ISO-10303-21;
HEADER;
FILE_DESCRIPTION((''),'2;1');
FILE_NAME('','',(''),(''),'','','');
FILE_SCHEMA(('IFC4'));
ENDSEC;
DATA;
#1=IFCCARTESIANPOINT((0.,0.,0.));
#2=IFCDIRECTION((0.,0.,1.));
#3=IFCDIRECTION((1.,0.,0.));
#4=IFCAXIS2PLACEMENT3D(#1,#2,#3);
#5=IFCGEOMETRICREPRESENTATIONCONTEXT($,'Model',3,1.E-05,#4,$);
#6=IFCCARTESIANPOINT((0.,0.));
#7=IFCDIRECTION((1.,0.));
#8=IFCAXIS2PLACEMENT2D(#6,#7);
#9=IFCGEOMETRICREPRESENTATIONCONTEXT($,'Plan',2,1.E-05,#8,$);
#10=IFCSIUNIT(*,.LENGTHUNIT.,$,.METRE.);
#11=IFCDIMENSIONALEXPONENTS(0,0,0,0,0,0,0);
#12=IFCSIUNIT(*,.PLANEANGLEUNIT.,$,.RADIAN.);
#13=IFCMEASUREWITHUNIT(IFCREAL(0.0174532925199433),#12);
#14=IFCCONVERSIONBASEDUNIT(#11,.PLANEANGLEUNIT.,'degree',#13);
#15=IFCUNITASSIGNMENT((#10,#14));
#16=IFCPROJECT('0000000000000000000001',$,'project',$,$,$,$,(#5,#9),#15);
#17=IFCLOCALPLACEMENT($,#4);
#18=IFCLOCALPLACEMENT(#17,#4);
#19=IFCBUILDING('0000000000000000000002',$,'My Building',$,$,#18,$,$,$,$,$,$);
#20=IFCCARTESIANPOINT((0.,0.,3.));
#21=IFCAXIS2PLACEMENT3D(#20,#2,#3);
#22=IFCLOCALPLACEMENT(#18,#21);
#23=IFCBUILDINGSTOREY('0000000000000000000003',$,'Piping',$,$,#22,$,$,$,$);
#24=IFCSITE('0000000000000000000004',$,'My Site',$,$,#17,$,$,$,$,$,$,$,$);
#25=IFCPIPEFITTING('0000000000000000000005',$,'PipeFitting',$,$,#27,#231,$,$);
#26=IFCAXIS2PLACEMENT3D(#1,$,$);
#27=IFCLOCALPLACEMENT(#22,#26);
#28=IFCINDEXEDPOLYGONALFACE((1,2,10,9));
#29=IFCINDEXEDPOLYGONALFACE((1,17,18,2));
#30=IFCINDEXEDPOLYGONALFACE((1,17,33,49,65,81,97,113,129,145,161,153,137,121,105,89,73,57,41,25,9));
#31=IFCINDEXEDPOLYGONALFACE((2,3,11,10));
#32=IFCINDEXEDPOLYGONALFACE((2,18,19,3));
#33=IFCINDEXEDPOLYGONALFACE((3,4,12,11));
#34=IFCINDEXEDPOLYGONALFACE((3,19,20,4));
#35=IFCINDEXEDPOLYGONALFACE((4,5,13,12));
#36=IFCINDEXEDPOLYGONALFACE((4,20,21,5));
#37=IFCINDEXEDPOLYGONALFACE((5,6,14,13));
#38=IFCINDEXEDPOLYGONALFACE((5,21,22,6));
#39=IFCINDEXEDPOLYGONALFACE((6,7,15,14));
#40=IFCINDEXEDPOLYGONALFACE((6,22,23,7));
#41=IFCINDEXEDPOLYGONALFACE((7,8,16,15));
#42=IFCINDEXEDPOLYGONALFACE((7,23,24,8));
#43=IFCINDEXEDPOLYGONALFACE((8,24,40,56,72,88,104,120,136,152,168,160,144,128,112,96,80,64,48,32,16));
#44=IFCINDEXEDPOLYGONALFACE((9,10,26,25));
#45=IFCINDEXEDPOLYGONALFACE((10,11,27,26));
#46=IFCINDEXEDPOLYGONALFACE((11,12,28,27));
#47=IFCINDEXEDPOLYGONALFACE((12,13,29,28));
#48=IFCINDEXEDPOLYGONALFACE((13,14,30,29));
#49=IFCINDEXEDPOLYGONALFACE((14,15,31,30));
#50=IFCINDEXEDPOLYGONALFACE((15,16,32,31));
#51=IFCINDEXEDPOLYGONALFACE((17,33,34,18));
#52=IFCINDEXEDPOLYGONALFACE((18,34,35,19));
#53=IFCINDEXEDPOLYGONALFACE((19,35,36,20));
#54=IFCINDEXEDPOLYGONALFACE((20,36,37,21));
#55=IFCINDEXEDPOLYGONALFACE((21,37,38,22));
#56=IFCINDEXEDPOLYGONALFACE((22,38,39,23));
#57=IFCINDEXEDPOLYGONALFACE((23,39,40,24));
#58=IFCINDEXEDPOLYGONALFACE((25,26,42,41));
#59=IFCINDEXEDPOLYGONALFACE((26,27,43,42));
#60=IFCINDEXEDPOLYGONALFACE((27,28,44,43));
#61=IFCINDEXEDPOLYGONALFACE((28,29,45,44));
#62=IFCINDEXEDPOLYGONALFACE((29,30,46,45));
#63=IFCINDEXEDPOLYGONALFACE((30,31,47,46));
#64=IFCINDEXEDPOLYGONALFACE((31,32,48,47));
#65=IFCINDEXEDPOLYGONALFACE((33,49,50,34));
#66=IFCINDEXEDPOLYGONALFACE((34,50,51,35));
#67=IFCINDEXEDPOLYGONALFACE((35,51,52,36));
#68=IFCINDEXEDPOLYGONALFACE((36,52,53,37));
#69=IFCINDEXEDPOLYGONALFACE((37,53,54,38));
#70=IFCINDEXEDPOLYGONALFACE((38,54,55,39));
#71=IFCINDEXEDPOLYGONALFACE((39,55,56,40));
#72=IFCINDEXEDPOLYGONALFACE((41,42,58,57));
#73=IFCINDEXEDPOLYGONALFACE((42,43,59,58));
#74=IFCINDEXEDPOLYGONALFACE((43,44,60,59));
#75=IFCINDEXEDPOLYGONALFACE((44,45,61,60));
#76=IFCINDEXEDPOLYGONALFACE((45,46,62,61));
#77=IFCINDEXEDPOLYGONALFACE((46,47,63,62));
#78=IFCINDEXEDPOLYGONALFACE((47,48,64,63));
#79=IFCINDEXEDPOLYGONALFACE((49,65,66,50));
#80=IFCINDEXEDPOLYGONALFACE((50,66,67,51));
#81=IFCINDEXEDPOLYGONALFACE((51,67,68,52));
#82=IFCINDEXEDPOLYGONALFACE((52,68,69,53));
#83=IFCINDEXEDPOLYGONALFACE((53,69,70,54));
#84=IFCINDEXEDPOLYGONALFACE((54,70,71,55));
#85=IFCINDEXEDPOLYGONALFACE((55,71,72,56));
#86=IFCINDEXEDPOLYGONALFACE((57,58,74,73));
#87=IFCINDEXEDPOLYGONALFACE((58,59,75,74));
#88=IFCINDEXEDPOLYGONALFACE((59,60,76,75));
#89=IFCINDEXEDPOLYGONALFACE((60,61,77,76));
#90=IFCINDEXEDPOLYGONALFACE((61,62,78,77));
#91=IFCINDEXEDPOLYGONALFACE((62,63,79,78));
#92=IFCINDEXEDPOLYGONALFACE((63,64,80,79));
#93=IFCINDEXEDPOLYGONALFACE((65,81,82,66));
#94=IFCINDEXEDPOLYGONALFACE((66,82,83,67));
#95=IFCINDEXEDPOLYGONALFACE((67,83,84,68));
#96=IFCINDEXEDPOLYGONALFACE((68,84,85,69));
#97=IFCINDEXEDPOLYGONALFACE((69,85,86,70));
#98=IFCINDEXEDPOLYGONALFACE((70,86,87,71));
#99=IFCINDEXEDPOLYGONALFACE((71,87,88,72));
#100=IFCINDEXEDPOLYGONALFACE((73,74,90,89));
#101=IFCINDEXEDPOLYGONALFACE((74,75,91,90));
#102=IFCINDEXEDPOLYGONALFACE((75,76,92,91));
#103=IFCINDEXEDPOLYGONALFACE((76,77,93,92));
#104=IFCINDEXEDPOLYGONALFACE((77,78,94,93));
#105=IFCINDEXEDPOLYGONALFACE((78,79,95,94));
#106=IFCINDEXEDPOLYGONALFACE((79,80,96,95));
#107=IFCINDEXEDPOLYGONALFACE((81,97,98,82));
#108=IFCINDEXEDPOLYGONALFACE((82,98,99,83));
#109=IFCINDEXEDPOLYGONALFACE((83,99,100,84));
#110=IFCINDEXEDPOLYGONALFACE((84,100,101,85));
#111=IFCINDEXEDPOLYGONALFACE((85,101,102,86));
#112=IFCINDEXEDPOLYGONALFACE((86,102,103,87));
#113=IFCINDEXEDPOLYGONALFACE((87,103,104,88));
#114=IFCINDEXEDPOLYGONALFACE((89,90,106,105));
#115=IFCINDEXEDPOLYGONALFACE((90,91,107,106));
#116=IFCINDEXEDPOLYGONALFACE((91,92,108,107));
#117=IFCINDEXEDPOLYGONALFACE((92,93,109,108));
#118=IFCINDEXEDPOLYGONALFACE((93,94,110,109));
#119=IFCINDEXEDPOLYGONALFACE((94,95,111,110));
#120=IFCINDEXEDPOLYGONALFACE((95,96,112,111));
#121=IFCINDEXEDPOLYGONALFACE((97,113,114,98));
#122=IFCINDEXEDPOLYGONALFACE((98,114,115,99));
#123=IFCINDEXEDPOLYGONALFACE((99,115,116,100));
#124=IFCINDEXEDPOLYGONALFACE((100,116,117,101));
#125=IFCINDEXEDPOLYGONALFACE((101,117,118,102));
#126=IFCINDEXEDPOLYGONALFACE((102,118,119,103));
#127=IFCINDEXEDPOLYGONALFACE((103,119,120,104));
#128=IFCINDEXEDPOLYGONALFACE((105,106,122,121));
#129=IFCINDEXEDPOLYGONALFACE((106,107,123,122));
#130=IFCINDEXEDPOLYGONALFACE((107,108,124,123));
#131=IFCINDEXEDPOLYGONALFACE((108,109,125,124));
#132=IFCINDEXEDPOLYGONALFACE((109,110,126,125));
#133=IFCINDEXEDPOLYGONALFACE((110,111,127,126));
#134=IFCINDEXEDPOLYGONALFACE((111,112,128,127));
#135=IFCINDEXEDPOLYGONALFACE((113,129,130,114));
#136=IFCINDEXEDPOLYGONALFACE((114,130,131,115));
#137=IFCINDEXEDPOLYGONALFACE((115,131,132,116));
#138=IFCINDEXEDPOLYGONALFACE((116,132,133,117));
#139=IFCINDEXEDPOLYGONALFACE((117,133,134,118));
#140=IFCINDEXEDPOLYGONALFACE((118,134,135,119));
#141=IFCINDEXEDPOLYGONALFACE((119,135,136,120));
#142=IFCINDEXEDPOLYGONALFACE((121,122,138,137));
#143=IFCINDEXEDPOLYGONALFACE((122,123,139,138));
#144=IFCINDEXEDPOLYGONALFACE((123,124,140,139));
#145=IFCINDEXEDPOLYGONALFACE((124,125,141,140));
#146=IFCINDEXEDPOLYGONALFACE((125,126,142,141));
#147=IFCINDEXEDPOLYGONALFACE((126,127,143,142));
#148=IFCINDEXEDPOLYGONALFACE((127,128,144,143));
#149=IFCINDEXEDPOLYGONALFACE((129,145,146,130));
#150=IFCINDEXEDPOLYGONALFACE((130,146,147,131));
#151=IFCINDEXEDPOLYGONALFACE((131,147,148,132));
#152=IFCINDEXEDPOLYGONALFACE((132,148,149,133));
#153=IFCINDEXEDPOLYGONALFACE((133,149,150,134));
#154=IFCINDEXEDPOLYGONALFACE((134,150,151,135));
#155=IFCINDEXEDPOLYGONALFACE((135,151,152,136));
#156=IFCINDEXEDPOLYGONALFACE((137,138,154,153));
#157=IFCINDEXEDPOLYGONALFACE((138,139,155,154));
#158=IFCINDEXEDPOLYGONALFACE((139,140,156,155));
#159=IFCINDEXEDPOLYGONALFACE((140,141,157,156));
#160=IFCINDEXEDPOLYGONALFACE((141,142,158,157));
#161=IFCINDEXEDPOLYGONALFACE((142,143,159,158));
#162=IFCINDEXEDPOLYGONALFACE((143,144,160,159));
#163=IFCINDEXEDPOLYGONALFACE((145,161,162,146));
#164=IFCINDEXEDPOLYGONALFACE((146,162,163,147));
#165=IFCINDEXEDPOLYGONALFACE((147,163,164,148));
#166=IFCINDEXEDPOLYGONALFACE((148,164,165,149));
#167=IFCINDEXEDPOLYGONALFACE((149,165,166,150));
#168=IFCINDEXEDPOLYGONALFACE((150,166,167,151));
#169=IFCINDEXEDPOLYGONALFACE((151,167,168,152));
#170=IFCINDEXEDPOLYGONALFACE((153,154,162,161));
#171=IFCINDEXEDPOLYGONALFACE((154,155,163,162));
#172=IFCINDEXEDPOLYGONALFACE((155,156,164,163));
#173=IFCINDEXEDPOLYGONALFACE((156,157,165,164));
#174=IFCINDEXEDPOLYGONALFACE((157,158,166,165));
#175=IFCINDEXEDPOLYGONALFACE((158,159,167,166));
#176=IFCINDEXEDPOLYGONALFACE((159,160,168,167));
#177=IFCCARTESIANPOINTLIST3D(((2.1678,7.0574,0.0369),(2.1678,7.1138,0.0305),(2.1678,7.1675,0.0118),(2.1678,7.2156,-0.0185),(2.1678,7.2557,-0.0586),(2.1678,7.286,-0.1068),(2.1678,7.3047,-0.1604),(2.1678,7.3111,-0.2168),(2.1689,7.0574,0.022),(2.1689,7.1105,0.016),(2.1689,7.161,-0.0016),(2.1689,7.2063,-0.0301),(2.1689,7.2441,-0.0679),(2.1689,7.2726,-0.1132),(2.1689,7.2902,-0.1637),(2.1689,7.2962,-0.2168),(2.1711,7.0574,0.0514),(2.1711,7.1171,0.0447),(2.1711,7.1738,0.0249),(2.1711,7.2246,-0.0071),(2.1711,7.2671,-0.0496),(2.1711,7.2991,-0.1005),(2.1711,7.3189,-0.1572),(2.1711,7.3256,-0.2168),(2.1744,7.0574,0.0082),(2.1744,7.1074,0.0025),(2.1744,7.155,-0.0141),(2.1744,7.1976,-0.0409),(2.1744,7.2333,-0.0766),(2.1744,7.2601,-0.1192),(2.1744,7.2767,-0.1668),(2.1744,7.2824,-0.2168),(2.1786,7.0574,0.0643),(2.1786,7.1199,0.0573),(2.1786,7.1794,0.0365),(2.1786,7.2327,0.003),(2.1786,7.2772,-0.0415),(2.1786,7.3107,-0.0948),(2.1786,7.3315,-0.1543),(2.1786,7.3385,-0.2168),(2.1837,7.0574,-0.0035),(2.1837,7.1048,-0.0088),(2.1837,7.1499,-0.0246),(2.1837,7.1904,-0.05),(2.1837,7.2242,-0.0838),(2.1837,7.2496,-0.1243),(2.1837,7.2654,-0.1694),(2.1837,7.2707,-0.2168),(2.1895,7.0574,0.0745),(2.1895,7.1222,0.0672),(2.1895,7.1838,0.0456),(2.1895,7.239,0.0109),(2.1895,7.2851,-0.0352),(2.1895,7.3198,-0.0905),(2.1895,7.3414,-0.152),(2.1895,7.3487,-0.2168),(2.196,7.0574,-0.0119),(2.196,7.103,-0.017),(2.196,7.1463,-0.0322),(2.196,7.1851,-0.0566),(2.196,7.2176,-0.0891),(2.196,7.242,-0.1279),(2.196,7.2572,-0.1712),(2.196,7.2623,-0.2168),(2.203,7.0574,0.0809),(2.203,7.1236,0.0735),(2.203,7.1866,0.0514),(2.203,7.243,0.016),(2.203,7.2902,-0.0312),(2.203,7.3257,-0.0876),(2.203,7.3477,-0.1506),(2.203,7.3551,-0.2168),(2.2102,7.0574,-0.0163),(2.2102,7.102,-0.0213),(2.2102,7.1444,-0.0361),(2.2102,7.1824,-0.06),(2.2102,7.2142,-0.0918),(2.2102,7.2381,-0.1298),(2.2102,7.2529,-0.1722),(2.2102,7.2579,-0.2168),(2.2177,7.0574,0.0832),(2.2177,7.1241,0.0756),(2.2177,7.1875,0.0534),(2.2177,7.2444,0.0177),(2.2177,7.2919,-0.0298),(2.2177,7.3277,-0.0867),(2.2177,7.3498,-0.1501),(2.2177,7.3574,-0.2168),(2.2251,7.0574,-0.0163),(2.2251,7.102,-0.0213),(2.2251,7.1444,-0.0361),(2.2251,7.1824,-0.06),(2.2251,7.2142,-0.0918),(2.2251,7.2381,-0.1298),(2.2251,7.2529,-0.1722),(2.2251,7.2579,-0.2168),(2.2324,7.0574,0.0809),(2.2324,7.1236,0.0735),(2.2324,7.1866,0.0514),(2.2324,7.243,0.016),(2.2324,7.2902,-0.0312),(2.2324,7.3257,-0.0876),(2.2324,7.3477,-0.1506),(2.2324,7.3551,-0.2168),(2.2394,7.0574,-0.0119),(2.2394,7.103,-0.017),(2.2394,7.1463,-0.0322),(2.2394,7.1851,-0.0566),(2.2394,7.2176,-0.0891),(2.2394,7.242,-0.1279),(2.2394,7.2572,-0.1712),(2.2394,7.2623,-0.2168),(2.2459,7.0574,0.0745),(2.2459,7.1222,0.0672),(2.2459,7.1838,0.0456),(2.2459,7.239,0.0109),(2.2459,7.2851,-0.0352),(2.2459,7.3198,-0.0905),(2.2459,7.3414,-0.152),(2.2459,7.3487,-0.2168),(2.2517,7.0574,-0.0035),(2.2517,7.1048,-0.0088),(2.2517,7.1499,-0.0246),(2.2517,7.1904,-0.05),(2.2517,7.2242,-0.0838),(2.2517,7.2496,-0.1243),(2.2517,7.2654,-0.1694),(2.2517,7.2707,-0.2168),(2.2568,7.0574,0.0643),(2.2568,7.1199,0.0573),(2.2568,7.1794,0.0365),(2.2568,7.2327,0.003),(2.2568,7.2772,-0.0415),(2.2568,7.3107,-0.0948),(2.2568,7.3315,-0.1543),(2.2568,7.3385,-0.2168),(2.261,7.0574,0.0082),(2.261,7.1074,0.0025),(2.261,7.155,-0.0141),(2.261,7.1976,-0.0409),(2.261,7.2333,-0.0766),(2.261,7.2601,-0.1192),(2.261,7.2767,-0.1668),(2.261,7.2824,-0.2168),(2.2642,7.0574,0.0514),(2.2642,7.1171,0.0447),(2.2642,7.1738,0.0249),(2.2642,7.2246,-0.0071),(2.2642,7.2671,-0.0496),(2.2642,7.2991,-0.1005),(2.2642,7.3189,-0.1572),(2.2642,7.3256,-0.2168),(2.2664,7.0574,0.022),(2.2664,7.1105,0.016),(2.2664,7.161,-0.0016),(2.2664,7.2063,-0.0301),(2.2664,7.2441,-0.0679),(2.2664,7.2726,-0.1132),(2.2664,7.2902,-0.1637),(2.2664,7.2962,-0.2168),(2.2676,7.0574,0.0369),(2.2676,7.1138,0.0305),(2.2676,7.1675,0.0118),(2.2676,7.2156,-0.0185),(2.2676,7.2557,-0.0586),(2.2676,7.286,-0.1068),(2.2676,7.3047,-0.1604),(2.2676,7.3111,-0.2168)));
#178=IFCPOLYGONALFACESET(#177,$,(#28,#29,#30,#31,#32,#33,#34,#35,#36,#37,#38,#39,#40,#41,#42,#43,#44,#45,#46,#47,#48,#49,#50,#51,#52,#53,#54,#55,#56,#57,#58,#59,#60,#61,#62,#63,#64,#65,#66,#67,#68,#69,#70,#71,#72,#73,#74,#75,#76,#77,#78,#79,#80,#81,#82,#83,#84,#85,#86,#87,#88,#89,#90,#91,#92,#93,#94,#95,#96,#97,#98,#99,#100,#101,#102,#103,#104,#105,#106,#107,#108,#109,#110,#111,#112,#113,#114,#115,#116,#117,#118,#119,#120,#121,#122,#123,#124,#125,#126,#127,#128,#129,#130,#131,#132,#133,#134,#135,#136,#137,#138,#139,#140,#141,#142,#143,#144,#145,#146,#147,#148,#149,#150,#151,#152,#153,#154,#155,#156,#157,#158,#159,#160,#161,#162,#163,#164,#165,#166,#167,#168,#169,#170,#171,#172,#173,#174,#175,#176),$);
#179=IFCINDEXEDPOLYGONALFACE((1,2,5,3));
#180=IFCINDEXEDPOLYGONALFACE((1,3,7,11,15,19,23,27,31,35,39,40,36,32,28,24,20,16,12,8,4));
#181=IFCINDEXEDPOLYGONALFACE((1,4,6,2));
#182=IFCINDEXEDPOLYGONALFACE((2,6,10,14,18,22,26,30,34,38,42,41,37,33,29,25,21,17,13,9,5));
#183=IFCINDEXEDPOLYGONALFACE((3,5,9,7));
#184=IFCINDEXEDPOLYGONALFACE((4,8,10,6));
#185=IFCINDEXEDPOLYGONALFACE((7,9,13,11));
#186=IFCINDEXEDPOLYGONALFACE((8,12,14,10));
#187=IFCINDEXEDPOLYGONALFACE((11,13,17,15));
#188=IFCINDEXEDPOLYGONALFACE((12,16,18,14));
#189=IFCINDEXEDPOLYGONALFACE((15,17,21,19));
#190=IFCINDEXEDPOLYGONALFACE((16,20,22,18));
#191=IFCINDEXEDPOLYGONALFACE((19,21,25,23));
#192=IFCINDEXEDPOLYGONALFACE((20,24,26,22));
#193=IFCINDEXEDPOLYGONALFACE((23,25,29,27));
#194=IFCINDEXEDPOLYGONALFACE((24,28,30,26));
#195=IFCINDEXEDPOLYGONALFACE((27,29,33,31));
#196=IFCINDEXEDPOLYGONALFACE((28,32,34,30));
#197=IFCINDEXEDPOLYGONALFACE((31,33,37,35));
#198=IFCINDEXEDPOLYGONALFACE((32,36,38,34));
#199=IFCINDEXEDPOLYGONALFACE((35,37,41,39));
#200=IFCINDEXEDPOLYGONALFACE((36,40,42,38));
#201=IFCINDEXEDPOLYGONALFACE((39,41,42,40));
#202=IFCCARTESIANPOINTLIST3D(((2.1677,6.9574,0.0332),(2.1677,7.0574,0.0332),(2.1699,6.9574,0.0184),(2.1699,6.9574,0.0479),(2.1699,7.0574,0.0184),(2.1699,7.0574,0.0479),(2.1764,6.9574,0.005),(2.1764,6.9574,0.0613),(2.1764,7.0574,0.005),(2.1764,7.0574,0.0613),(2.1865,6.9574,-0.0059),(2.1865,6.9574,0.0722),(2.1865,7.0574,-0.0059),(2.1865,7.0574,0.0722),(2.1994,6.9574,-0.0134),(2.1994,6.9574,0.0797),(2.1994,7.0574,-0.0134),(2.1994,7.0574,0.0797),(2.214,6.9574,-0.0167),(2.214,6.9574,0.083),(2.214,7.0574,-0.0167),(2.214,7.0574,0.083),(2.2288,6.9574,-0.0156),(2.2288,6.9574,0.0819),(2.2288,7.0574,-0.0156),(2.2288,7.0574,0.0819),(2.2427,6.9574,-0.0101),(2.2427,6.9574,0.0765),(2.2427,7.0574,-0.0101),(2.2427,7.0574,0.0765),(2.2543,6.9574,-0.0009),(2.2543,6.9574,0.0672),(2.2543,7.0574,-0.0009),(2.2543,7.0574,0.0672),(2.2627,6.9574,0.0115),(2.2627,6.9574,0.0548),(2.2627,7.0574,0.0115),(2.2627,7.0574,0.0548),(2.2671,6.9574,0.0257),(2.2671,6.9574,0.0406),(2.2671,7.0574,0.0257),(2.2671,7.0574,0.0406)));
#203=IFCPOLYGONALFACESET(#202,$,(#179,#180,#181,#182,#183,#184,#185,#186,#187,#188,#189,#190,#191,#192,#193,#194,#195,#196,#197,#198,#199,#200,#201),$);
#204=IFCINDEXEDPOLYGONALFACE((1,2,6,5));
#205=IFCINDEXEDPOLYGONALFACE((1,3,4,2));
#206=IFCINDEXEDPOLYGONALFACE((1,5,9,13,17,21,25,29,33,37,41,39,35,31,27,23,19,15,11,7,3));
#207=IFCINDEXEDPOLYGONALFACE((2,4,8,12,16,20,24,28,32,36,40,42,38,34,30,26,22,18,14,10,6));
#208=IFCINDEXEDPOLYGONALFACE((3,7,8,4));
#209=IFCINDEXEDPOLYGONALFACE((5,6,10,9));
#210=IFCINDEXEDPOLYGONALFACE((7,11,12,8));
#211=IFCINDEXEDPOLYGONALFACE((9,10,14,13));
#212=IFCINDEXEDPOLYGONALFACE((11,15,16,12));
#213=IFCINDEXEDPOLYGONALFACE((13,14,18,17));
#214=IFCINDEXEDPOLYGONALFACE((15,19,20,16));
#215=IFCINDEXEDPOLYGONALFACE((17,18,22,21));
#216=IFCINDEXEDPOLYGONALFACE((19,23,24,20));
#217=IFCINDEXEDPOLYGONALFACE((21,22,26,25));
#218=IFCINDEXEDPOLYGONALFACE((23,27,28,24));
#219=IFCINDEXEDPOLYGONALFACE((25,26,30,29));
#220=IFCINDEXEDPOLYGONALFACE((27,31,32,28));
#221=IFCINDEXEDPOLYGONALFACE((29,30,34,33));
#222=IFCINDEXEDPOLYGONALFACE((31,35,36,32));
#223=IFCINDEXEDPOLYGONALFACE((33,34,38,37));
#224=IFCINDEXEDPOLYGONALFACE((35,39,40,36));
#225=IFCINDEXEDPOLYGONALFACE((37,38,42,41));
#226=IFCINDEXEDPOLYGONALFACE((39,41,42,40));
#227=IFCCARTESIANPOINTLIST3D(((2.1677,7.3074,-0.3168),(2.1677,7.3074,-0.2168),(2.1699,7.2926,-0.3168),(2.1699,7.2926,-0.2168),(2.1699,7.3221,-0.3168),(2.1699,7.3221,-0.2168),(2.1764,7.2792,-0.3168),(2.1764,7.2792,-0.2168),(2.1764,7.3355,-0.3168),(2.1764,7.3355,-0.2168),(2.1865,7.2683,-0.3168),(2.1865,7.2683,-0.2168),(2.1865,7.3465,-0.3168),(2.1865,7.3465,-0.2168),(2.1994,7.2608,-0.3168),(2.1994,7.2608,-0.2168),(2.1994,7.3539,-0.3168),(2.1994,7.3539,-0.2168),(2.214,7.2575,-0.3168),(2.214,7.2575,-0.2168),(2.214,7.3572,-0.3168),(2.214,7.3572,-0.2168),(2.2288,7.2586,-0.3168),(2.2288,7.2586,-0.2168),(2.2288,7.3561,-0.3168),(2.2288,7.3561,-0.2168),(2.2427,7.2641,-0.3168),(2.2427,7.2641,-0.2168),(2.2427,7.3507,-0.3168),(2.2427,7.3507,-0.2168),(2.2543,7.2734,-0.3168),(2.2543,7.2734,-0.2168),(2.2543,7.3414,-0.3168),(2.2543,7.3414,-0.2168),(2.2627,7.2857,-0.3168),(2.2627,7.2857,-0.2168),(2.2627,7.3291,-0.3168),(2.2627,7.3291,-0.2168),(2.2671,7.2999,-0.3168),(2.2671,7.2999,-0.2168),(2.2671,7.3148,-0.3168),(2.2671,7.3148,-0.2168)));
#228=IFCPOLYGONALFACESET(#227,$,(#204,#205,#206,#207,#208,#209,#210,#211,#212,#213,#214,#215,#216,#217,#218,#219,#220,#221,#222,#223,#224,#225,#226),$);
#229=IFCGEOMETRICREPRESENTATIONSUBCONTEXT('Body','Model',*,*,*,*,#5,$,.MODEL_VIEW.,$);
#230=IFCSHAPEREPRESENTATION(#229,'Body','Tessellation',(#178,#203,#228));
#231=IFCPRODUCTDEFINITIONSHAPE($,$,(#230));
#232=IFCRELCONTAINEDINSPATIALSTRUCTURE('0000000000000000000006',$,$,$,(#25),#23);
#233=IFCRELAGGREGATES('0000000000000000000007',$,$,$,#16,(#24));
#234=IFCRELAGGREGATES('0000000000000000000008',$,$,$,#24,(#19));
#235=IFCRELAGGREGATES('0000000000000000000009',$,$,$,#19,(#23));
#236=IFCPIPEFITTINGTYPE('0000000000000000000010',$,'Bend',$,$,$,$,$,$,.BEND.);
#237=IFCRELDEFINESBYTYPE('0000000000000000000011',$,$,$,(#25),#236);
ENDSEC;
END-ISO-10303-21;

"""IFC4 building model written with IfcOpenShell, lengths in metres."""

from ifc_helpers import new_model, entity, si_unit, converted_unit, frame, origin_with_axes, origin_2d_with_axis, place, context, subcontext, project, spatial, circle, extrude, source, transform, mapped, type_object, type_shapes, element, save


model = new_model("IFC4")

# Units and contexts
model_context = context("Model", 3, precision=1e-05, world=origin_with_axes())
plan_context = context("Plan", 2, precision=1e-05, world=origin_2d_with_axis())
body_context = subcontext(model_context, "Body", "Model", "MODEL_VIEW")
ifc_project = project(units=[si_unit("LENGTHUNIT", "METRE"), converted_unit("PLANEANGLEUNIT", "degree", entity("IfcReal", 0.0174532925199433), si_unit("PLANEANGLEUNIT", "RADIAN"), dimensions=[0, 0, 0, 0, 0, 0, 0])], contexts=[model_context, plan_context])

# Site, building, storey
site_placement = place(None, origin_with_axes())
site = spatial("IfcSite", under=ifc_project, at=site_placement, Name="My Site")
building_placement = place(site_placement, origin_with_axes())
building = spatial("IfcBuilding", under=site, at=building_placement, Name="My Building")
storey_placement = place(building_placement, frame((0.0, 0.0, 3.0), z_axis=(0.0, 0.0, 1.0), x_axis=(1.0, 0.0, 0.0)))
storey = spatial("IfcBuildingStorey", under=building, at=storey_placement, Name="Piping")

# Pipe fitting
pipe_fitting_type = type_object("IfcPipeFittingType", Name="Bend", PredefinedType="BEND")
shared_shape = source(origin_with_axes(), body_context, "Body", "SolidModel", [
    entity("IfcSweptDiskSolid", entity("IfcIndexedPolyCurve", entity("IfcCartesianPointList3D", [[0.0, 0.0, -0.1], [0.0, 0.0732, -0.2768], [0.0, 0.25, -0.35]]), [entity("IfcArcIndex", [1, 2, 3])]), 0.05),
    extrude(circle(Radius=0.05), origin_with_axes(), (0.0, 0.0, -1.0), 0.1),
    extrude(circle(Radius=0.05), frame((0.0, 0.25, -0.35), z_axis=(0.0, 1.0, 0.0), x_axis=(1.0, 0.0, 0.0)), (0.0, 0.0, 1.0), 0.1),
])
type_shapes(pipe_fitting_type, [shared_shape])
for number, where, z_axis, x_axis, name in (
    (1, (2.2177, 6.9574, 0.0332), (0.0, -1.0, 0.0), (-1.0, 0.0, 0.0), "PipeFitting"),
):
    element("IfcPipeFitting", number, at=place(storey_placement, frame(where, z_axis=z_axis, x_axis=x_axis)), inside=storey, type_object=pipe_fitting_type, Name=name, context=body_context, shape_type="MappedRepresentation", body=[
        mapped(shared_shape, transform((0.0, 0.0, 0.0), x_axis=(1.0, 0.0, 0.0), y_axis=(0.0, 1.0, 0.0), z_axis=(0.0, 0.0, 1.0), scale=1.0)),
    ])

save(model, "model.ifc")
